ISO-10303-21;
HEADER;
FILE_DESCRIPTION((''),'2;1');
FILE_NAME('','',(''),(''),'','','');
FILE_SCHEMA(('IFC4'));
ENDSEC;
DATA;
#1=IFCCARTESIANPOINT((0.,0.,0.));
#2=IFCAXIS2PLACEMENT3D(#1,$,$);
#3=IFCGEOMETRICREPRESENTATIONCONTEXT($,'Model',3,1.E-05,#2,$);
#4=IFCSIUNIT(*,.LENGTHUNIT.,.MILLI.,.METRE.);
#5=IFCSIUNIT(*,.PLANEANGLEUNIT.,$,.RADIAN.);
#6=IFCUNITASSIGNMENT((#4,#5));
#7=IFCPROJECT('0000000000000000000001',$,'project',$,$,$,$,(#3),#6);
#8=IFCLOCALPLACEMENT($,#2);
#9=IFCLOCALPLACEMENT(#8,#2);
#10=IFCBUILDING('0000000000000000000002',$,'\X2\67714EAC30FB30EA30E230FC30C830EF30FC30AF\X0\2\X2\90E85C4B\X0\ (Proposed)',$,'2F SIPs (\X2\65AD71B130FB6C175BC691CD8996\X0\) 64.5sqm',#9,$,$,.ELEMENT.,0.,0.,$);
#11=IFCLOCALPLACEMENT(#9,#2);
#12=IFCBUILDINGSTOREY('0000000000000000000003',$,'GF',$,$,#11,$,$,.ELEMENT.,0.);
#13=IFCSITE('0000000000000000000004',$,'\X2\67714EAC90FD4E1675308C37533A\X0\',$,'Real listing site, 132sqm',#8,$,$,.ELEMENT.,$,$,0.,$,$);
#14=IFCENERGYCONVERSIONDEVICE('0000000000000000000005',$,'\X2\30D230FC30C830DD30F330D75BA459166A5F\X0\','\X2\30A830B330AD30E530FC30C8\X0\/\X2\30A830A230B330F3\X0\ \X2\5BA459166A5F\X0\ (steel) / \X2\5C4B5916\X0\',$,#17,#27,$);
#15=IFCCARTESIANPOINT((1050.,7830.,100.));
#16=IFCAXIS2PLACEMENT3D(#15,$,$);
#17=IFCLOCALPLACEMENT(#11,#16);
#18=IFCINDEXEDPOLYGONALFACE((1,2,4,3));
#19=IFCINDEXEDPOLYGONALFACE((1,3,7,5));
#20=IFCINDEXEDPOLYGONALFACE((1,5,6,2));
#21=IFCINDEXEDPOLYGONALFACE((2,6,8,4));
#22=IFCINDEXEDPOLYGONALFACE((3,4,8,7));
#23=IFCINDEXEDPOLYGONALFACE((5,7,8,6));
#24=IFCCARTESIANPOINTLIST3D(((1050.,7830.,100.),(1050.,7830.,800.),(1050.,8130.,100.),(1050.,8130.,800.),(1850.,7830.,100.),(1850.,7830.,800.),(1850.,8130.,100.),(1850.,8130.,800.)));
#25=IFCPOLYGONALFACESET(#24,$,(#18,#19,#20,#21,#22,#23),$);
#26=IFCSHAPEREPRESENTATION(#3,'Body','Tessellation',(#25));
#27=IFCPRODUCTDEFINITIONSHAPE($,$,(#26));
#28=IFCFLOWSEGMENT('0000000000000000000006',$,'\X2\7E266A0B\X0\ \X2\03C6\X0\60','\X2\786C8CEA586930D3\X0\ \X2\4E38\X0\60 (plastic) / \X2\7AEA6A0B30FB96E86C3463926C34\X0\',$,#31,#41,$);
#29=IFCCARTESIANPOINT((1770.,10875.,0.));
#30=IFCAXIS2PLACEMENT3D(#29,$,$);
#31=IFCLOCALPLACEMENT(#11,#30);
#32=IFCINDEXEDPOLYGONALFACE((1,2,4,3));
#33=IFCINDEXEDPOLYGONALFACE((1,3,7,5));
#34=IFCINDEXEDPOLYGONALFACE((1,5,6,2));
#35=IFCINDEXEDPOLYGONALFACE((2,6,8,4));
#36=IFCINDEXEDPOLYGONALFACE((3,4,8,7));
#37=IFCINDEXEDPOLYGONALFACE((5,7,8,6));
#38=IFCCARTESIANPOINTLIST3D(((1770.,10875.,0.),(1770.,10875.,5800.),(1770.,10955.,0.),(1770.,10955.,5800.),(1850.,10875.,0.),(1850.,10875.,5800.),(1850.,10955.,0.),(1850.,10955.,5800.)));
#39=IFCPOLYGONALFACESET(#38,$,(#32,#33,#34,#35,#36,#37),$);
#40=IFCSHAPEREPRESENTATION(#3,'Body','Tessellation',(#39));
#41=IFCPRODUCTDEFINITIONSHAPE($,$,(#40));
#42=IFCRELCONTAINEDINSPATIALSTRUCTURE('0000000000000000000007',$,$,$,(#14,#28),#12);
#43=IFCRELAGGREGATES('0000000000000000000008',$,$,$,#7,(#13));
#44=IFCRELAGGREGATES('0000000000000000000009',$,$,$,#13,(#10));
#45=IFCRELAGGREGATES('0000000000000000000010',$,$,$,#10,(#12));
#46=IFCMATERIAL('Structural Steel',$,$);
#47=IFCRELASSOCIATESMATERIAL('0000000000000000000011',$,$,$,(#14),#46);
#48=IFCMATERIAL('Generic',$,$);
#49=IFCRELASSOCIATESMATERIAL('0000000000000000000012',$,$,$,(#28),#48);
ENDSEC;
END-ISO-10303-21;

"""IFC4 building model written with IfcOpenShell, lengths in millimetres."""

from ifc_helpers import new_model, si_unit, frame, frame_2d, origin, place, context, project, spatial, rectangle, extrude, material, element, save


model = new_model("IFC4")

# Units and contexts
model_context = context("Model", 3, precision=1e-05, world=origin())
ifc_project = project(units=[si_unit("LENGTHUNIT", "METRE", prefix="MILLI"), si_unit("PLANEANGLEUNIT", "RADIAN")], contexts=[model_context])

# Site, building, storey
site_placement = place(None, origin())
site = spatial("IfcSite", under=ifc_project, at=site_placement, Name="東京都世田谷区", ObjectType="Real listing site, 132sqm", CompositionType="ELEMENT", RefElevation=0.0)
building_placement = place(site_placement, origin())
building = spatial("IfcBuilding", under=site, at=building_placement, Name="東京・リモートワーク2部屋 (Proposed)", ObjectType="2F SIPs (断熱・気密重視) 64.5sqm", CompositionType="ELEMENT", ElevationOfRefHeight=0.0, ElevationOfTerrain=0.0)
storey_placement = place(building_placement, origin())
storey = spatial("IfcBuildingStorey", under=building, at=storey_placement, Name="GF", CompositionType="ELEMENT", Elevation=0.0)

# Shared definitions
ifc_material_1 = material(Name="Generic")

# Energy conversion device
ifc_material_2 = material(Name="Structural Steel")
energy_conversion_device_placement = place(storey_placement, frame((1050.0, 7830.0, 100.0)))
element("IfcEnergyConversionDevice", 1, at=energy_conversion_device_placement, inside=storey, material=ifc_material_2, Name="ヒートポンプ室外機", Description="エコキュート/エアコン 室外機 (steel) / 屋外", context=model_context, shape_type="SweptSolid", body=[
    extrude(rectangle(XDim=800.0, YDim=300.0, at=frame_2d((400.0, 150.0))), frame((1050.0, 7830.0, 100.0)), (0.0, 0.0, 1.0), 700.0),
])

# Flow segment
flow_segment_placement = place(storey_placement, frame((1770.0, 10875.0, 0.0)))
element("IfcFlowSegment", 2, at=flow_segment_placement, inside=storey, material=ifc_material_1, Name="縦樋 φ60", Description="硬質塩ビ 丸60 (plastic) / 竪樋・雨水排水", context=model_context, shape_type="SweptSolid", body=[
    extrude(rectangle(XDim=80.0, YDim=80.0, at=frame_2d((40.0, 40.0))), frame((1770.0, 10875.0, 0.0)), (0.0, 0.0, 1.0), 5800.0),
])

save(model, "model.ifc")
